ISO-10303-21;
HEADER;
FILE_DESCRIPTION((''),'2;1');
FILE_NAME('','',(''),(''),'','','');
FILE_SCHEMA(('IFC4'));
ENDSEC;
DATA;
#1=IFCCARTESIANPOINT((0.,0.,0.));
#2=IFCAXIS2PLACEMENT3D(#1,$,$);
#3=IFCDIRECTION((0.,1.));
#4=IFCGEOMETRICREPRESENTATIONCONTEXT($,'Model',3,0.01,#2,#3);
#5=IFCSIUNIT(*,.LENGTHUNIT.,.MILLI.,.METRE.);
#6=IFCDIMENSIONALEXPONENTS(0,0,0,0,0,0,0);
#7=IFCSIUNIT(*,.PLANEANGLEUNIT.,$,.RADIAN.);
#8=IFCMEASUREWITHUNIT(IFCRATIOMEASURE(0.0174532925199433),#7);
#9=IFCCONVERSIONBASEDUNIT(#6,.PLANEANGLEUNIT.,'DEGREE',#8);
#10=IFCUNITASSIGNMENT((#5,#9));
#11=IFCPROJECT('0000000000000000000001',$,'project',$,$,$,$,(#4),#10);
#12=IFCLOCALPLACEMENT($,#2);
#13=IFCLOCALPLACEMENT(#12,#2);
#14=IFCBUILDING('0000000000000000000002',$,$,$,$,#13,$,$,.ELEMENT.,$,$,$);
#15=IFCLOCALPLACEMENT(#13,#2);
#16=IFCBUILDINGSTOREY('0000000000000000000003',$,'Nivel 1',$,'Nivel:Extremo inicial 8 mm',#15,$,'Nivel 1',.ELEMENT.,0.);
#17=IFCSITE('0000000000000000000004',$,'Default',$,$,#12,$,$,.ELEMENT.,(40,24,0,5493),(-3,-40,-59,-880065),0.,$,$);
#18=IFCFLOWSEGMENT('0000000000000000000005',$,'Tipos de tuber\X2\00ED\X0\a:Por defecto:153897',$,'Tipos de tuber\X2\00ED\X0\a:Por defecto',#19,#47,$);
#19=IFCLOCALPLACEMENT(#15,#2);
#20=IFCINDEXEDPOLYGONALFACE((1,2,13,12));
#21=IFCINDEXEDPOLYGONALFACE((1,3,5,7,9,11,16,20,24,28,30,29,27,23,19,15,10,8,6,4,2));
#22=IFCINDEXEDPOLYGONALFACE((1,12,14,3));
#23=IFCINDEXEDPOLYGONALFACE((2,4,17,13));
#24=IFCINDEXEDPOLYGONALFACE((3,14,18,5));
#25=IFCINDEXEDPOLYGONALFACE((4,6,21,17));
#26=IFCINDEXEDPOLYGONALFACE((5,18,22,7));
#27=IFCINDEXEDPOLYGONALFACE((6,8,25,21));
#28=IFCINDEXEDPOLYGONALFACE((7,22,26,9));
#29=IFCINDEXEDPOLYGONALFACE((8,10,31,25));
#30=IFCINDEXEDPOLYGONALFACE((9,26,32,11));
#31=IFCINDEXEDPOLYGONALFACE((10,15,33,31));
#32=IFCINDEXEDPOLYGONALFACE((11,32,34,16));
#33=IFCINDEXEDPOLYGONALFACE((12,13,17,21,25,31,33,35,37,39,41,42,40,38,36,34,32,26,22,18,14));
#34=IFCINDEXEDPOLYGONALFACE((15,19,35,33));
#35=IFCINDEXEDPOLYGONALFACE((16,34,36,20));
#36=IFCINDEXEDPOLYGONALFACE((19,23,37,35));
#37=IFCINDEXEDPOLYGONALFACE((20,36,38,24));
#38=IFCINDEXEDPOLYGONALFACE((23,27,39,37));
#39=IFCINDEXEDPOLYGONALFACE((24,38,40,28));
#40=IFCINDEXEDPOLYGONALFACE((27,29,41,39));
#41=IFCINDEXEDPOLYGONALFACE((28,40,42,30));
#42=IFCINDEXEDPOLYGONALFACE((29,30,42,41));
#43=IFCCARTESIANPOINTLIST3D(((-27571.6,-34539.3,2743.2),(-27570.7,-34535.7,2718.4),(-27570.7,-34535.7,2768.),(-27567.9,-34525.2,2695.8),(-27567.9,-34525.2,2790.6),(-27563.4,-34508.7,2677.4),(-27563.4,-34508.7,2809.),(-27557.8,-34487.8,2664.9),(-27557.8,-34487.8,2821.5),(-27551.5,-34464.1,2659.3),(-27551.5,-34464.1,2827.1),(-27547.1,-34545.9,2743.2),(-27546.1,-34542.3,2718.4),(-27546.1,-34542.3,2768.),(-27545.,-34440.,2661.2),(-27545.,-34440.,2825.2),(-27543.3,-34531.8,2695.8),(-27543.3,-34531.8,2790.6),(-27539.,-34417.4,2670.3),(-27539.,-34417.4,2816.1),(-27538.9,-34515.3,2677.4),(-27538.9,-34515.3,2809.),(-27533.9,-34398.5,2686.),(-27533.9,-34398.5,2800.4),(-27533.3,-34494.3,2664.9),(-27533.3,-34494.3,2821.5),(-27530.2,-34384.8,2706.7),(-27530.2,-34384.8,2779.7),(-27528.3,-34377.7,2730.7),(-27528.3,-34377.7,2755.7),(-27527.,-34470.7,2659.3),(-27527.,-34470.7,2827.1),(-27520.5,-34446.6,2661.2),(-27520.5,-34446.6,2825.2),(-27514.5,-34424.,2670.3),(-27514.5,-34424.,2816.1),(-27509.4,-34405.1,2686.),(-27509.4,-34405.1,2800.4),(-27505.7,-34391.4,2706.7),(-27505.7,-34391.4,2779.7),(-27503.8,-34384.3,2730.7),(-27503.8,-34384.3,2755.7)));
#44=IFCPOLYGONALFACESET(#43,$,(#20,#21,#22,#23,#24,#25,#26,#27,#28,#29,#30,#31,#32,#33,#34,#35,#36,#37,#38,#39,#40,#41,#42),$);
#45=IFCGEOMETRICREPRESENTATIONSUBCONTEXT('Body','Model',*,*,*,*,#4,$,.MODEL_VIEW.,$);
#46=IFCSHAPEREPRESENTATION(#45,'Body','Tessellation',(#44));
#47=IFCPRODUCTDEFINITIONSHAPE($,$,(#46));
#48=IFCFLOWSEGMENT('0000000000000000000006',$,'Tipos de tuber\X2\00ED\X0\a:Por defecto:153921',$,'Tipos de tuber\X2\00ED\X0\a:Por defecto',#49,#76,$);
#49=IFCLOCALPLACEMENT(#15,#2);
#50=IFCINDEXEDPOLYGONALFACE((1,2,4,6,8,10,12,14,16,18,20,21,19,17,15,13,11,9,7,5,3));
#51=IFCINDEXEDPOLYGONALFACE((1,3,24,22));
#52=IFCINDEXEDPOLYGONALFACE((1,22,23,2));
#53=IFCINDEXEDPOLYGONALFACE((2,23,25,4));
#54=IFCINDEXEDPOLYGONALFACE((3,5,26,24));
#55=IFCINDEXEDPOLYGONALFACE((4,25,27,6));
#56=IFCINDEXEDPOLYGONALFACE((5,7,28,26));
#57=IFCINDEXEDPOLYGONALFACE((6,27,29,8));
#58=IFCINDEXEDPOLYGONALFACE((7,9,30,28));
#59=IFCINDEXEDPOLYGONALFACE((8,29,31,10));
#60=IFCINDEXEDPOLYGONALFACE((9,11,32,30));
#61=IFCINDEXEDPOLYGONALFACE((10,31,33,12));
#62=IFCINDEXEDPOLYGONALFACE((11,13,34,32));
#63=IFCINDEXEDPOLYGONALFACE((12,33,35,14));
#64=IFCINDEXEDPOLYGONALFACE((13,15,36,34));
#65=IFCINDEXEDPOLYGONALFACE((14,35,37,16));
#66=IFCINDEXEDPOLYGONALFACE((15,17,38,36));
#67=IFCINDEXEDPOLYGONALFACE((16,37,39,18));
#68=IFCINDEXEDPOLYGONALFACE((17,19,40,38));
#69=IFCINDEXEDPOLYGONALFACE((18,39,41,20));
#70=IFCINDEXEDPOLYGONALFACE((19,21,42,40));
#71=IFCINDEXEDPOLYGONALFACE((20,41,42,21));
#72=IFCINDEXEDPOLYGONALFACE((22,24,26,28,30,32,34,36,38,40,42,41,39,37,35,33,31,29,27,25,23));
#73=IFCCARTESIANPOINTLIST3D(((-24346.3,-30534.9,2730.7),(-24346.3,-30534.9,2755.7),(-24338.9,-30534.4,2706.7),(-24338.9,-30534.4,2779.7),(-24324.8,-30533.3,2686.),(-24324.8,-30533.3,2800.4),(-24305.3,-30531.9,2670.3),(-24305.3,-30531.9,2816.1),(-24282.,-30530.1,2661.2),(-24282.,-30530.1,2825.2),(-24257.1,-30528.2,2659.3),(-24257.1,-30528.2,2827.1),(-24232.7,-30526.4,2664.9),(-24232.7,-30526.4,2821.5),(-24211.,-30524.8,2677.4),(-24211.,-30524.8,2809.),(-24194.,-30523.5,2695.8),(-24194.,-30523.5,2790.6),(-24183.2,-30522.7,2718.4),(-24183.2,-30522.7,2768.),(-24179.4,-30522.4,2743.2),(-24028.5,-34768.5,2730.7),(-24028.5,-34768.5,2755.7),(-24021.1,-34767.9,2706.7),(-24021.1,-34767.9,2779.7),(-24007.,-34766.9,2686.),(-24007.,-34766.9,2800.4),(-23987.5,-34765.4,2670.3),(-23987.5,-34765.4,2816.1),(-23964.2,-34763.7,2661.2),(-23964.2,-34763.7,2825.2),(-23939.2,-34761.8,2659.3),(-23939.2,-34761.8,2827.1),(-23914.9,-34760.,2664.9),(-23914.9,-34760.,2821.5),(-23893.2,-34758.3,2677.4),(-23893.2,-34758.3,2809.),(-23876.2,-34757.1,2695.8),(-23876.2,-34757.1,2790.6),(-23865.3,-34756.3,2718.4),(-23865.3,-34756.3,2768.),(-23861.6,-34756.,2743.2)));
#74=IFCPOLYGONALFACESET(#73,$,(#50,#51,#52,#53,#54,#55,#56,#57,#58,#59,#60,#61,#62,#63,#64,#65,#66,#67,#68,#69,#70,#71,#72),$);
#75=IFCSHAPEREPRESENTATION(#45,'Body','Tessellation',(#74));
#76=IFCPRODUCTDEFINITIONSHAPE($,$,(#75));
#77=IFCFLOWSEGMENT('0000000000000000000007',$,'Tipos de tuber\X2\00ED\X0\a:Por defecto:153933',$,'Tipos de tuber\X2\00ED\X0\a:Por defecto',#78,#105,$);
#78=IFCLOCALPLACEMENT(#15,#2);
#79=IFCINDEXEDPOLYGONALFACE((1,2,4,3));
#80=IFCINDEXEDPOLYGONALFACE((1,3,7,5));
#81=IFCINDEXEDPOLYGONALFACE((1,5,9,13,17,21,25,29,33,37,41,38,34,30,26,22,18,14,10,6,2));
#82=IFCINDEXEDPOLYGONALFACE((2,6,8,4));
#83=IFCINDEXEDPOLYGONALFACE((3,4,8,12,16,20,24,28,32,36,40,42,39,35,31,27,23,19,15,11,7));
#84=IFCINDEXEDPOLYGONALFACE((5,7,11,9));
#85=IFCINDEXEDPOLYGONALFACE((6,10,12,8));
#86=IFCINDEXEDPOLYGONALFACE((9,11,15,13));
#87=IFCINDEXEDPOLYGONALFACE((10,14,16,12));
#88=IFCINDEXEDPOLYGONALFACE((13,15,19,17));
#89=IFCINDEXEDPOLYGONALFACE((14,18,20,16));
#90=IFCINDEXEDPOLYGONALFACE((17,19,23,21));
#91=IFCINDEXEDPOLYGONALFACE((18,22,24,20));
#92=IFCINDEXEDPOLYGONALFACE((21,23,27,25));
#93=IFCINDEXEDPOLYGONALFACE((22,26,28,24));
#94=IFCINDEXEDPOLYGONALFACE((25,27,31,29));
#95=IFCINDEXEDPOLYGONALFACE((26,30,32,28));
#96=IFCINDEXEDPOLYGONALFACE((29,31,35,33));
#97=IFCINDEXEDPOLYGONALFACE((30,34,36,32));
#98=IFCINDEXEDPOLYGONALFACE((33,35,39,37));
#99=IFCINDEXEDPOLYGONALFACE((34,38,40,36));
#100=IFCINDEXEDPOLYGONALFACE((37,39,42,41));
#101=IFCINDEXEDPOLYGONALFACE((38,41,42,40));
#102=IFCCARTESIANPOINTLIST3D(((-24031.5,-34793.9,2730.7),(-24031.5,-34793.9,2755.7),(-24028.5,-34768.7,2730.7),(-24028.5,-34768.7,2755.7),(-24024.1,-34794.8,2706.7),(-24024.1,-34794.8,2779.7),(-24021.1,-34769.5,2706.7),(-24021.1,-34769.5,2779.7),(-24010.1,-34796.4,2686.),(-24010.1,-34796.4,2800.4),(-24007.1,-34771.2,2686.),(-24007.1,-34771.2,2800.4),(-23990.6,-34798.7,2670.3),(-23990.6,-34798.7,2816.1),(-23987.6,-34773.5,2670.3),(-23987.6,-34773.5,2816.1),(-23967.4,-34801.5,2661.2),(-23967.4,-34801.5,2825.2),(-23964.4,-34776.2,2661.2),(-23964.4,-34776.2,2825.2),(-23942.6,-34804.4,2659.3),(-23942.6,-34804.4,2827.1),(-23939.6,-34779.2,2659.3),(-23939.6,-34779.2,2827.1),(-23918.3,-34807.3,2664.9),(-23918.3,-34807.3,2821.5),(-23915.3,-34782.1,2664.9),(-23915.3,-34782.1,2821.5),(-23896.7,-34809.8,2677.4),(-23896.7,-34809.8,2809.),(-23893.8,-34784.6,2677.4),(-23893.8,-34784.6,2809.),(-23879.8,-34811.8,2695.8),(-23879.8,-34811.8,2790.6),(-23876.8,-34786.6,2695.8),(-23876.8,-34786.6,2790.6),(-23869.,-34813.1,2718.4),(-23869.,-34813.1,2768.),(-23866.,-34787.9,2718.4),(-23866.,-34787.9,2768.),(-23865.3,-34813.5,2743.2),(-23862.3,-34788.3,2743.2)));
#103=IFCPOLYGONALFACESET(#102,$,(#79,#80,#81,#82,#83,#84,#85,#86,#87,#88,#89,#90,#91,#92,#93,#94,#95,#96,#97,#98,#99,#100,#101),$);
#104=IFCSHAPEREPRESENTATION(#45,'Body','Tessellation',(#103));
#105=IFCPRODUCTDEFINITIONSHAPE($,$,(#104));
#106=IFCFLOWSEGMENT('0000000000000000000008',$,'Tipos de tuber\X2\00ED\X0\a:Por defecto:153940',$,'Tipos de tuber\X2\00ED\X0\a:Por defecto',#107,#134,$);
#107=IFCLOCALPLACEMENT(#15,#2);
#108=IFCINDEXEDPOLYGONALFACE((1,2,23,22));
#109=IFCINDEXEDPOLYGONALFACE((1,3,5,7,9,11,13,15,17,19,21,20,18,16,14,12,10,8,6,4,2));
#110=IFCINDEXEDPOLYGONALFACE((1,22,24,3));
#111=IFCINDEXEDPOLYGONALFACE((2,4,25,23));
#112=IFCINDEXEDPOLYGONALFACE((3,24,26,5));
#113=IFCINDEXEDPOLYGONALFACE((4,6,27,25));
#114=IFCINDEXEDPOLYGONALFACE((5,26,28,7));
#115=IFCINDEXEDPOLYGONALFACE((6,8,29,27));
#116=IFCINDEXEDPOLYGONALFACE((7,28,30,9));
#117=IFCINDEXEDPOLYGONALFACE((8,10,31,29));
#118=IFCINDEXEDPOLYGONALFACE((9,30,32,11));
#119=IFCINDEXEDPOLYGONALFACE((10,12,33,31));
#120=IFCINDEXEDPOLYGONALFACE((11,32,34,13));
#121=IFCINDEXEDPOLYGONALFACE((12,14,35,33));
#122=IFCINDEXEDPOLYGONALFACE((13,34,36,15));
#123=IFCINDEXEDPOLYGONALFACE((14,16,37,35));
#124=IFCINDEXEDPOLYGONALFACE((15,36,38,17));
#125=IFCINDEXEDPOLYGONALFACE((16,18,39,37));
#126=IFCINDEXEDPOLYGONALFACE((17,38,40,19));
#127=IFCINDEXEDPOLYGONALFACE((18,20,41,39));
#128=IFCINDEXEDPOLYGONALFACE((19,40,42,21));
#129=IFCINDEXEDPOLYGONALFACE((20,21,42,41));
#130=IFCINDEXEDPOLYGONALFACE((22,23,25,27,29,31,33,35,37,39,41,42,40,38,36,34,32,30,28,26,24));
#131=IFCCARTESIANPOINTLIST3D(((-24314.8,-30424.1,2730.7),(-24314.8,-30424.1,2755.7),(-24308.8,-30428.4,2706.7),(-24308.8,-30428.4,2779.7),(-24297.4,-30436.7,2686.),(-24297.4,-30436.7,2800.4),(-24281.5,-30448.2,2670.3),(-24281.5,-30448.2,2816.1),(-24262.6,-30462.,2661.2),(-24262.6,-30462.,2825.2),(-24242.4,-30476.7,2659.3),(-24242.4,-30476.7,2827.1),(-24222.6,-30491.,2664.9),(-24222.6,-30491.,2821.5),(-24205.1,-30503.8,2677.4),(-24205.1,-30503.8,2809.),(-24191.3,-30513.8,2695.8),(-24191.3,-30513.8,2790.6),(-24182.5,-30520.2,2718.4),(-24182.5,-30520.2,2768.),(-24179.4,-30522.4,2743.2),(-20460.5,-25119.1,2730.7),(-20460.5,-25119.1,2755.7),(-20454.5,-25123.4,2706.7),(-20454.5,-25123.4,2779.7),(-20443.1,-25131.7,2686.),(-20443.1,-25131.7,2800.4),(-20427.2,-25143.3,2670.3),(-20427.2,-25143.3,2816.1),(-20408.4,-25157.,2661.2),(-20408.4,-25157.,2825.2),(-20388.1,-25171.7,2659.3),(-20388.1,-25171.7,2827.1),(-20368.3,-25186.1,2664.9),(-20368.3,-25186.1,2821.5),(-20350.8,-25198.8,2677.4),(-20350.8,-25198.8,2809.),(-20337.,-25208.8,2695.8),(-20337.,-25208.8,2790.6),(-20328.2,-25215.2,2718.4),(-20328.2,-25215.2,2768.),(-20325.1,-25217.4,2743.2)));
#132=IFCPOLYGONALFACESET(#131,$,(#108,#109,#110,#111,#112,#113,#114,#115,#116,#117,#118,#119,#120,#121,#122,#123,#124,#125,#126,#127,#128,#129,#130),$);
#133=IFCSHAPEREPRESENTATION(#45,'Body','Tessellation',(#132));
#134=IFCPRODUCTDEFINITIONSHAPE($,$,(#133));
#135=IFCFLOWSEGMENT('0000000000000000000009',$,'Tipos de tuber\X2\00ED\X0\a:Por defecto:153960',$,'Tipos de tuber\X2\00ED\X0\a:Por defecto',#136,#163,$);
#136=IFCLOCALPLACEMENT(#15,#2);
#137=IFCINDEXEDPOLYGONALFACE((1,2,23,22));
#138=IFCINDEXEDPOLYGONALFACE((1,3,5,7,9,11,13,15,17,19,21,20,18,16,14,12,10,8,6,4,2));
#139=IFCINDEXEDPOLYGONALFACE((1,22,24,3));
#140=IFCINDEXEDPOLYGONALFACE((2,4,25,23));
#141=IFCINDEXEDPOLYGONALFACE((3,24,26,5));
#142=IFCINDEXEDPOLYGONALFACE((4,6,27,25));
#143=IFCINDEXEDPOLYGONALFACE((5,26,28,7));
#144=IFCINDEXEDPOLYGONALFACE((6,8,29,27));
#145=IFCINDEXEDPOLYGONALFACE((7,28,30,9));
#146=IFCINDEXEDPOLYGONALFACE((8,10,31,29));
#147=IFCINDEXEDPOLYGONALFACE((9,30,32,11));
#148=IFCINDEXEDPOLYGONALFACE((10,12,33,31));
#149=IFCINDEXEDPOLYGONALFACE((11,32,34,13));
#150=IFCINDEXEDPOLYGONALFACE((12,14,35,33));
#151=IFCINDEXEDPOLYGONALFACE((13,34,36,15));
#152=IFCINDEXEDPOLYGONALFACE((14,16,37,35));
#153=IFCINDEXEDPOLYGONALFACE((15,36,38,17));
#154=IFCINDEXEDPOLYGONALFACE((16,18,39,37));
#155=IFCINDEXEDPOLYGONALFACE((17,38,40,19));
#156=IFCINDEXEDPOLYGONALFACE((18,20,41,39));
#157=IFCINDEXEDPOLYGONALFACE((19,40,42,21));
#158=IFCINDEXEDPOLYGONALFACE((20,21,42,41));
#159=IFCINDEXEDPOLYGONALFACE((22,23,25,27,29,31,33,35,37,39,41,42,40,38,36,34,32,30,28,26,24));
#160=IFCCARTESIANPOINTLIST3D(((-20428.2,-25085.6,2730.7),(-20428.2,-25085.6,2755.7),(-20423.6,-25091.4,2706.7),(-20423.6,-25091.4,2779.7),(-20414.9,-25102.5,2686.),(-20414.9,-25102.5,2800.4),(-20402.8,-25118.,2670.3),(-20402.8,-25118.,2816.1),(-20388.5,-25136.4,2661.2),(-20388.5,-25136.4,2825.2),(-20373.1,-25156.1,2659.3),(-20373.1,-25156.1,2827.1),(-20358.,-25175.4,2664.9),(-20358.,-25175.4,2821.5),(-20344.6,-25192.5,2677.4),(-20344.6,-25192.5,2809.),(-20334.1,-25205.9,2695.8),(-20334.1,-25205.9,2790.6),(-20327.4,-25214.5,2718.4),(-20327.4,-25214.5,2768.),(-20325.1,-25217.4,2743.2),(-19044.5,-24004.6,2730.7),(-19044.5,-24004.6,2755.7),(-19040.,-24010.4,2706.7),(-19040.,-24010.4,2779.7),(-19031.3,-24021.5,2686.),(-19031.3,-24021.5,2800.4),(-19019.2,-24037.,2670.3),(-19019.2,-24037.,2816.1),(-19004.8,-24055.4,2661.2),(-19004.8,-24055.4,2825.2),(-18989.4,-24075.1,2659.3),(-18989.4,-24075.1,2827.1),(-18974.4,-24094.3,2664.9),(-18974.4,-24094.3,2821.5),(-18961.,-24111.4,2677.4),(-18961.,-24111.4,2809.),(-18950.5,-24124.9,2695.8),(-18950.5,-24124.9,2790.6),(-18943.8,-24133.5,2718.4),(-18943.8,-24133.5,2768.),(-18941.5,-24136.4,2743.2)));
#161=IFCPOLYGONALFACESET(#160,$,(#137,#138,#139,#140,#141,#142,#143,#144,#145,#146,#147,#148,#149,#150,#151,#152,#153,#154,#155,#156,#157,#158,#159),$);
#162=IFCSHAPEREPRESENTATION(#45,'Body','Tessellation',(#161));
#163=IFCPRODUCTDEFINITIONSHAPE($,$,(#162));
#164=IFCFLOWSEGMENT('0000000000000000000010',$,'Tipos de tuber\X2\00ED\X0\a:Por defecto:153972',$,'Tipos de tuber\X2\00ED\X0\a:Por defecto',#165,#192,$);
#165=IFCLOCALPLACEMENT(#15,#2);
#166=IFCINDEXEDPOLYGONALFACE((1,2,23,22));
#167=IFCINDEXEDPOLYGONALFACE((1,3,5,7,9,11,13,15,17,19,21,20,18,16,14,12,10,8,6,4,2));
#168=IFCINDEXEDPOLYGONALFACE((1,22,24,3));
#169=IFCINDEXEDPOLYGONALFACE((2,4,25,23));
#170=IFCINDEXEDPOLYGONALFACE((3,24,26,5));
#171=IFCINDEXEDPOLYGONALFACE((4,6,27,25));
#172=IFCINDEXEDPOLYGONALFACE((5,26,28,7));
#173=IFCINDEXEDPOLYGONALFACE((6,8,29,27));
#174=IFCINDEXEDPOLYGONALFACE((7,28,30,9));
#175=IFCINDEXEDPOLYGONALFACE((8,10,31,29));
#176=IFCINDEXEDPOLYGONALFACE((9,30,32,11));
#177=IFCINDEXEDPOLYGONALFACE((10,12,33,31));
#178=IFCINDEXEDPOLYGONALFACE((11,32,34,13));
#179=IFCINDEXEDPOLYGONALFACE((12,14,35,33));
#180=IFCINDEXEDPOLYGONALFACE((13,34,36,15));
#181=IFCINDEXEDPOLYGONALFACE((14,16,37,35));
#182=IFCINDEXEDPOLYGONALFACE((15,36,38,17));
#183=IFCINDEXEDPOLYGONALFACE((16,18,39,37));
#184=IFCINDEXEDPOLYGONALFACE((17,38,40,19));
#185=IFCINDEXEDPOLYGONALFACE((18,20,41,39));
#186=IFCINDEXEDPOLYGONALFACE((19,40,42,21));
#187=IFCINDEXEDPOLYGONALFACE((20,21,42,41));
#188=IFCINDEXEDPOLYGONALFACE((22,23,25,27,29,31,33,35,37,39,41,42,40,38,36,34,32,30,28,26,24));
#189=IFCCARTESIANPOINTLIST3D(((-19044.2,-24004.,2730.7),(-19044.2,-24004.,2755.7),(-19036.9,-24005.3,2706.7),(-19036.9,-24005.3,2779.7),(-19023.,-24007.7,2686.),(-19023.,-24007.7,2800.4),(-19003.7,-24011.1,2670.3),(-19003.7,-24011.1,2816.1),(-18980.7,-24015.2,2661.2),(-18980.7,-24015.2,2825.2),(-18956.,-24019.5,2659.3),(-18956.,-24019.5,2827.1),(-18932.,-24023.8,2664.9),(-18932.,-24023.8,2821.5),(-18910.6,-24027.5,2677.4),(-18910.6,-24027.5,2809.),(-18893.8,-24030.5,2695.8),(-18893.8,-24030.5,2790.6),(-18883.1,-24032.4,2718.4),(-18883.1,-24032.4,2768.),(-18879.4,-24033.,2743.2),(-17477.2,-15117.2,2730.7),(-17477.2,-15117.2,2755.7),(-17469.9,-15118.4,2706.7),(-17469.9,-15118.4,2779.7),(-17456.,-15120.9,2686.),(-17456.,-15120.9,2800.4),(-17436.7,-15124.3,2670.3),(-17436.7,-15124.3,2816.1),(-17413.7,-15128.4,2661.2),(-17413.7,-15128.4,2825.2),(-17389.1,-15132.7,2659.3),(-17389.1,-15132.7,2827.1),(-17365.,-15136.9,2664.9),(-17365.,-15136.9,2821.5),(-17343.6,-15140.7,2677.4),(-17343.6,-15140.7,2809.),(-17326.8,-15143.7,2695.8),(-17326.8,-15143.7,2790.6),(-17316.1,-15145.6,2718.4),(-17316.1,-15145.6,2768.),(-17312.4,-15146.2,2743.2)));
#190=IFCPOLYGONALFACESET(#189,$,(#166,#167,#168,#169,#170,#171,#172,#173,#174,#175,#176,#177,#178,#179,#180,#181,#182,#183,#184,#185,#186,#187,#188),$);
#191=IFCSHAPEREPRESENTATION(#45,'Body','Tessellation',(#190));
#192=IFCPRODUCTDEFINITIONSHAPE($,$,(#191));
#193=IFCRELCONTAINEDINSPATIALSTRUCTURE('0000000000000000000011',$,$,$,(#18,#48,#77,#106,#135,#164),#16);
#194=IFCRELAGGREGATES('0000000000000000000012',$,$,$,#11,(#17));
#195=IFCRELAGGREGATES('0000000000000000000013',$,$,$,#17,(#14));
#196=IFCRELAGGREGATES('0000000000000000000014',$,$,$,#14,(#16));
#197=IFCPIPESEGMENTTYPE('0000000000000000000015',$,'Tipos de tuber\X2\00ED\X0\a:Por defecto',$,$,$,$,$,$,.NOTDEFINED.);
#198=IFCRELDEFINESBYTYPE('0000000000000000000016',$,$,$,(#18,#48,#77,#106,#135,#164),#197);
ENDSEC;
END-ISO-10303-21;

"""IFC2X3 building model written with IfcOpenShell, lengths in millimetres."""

from ifc_helpers import new_model, entity, si_unit, converted_unit, direction, frame, frame_2d, origin, origin_2d_with_axis, place, context, subcontext, project, spatial, circle, extrude, type_object, element, save


model = new_model("IFC2X3")

# Units and contexts
model_context = context("Model", 3, precision=0.01, world=origin(), true_north=direction((0.0, 1.0)))
body_context = subcontext(model_context, "Body", "Model", "MODEL_VIEW")
ifc_project = project(units=[si_unit("LENGTHUNIT", "METRE", prefix="MILLI"), converted_unit("PLANEANGLEUNIT", "DEGREE", entity("IfcRatioMeasure", 0.0174532925199433), si_unit("PLANEANGLEUNIT", "RADIAN"), dimensions=[0, 0, 0, 0, 0, 0, 0])], contexts=[model_context])

# Site, building, storey
site_placement = place(None, origin())
site = spatial("IfcSite", under=ifc_project, at=site_placement, Name="Default", CompositionType="ELEMENT", RefLatitude=(40, 24, 0, 5493), RefLongitude=(-3, -40, -59, -880065), RefElevation=0.0)
building_placement = place(site_placement, origin())
building = spatial("IfcBuilding", under=site, at=building_placement, CompositionType="ELEMENT")
storey_placement = place(building_placement, origin())
storey = spatial("IfcBuildingStorey", under=building, at=storey_placement, Name="Nivel 1", ObjectType="Nivel:Extremo inicial 8 mm", LongName="Nivel 1", CompositionType="ELEMENT", Elevation=0.0)

# Flow segments
pipe_segment_type = type_object("IfcPipeSegmentType", Name="Tipos de tubería:Por defecto", PredefinedType="NOTDEFINED")
flow_segment_1_placement = place(storey_placement, origin())
element("IfcFlowSegment", 1, at=flow_segment_1_placement, inside=storey, type_object=pipe_segment_type, Name="Tipos de tubería:Por defecto:153897", ObjectType="Tipos de tubería:Por defecto", context=body_context, shape_type="SweptSolid", body=[
    extrude(circle(Radius=84.1, at=frame_2d((0.0, 0.0), x_axis=(1.0, 0.0))), frame((-27549.9, -34458.1, 2743.2), z_axis=(0.965926, -0.258819, 0.0), x_axis=(-0.258819, -0.965926, 0.0)), (0.0, 0.0, 1.0), 25.4),
])
flow_segment_2_placement = place(storey_placement, origin())
element("IfcFlowSegment", 2, at=flow_segment_2_placement, inside=storey, type_object=pipe_segment_type, Name="Tipos de tubería:Por defecto:153921", ObjectType="Tipos de tubería:Por defecto", context=body_context, shape_type="SweptSolid", body=[
    extrude(circle(Radius=84.1, at=frame_2d((0.0, 0.0), x_axis=(1.0, 0.0))), frame((-23945.5, -34762.3, 2743.2), z_axis=(-0.074862, 0.997194, 0.0), x_axis=(0.997194, 0.074862, 0.0)), (0.0, 0.0, 1.0), 4245.5),
])
flow_segment_3_placement = place(storey_placement, origin())
element("IfcFlowSegment", 3, at=flow_segment_3_placement, inside=storey, type_object=pipe_segment_type, Name="Tipos de tubería:Por defecto:153933", ObjectType="Tipos de tubería:Por defecto", context=body_context, shape_type="SweptSolid", body=[
    extrude(circle(Radius=84.1, at=frame_2d((0.0, 0.0), x_axis=(1.0, 0.0))), frame((-23948.8, -34803.7, 2743.2), z_axis=(0.117415, 0.993083, 0.0), x_axis=(0.993083, -0.117415, 0.0)), (0.0, 0.0, 1.0), 25.4),
])
flow_segment_4_placement = place(storey_placement, origin())
element("IfcFlowSegment", 4, at=flow_segment_4_placement, inside=storey, type_object=pipe_segment_type, Name="Tipos de tubería:Por defecto:153940", ObjectType="Tipos de tubería:Por defecto", context=body_context, shape_type="SweptSolid", body=[
    extrude(circle(Radius=84.1, at=origin_2d_with_axis()), frame((-24247.5, -30473.0, 2743.2), z_axis=(0.587785, 0.809017, 0.0), x_axis=(0.809017, -0.587785, 0.0)), (0.0, 0.0, 1.0), 6557.3),
])
flow_segment_5_placement = place(storey_placement, origin())
element("IfcFlowSegment", 5, at=flow_segment_5_placement, inside=storey, type_object=pipe_segment_type, Name="Tipos de tubería:Por defecto:153960", ObjectType="Tipos de tubería:Por defecto", context=body_context, shape_type="SweptSolid", body=[
    extrude(circle(Radius=84.1, at=origin_2d_with_axis()), frame((-20376.9, -25151.1, 2743.2), z_axis=(0.788011, 0.615661, 0.0), x_axis=(0.615661, -0.788011, 0.0)), (0.0, 0.0, 1.0), 1755.9),
])
flow_segment_6_placement = place(storey_placement, origin())
element("IfcFlowSegment", 6, at=flow_segment_6_placement, inside=storey, type_object=pipe_segment_type, Name="Tipos de tubería:Por defecto:153972", ObjectType="Tipos de tubería:Por defecto", context=body_context, shape_type="SweptSolid", body=[
    extrude(circle(Radius=84.1, at=frame_2d((0.0, 0.0), x_axis=(1.0, 0.0))), frame((-18962.2, -24018.4, 2743.2), z_axis=(0.173648, 0.984808, 0.0), x_axis=(0.984808, -0.173648, 0.0)), (0.0, 0.0, 1.0), 9023.9),
])

save(model, "model.ifc")
